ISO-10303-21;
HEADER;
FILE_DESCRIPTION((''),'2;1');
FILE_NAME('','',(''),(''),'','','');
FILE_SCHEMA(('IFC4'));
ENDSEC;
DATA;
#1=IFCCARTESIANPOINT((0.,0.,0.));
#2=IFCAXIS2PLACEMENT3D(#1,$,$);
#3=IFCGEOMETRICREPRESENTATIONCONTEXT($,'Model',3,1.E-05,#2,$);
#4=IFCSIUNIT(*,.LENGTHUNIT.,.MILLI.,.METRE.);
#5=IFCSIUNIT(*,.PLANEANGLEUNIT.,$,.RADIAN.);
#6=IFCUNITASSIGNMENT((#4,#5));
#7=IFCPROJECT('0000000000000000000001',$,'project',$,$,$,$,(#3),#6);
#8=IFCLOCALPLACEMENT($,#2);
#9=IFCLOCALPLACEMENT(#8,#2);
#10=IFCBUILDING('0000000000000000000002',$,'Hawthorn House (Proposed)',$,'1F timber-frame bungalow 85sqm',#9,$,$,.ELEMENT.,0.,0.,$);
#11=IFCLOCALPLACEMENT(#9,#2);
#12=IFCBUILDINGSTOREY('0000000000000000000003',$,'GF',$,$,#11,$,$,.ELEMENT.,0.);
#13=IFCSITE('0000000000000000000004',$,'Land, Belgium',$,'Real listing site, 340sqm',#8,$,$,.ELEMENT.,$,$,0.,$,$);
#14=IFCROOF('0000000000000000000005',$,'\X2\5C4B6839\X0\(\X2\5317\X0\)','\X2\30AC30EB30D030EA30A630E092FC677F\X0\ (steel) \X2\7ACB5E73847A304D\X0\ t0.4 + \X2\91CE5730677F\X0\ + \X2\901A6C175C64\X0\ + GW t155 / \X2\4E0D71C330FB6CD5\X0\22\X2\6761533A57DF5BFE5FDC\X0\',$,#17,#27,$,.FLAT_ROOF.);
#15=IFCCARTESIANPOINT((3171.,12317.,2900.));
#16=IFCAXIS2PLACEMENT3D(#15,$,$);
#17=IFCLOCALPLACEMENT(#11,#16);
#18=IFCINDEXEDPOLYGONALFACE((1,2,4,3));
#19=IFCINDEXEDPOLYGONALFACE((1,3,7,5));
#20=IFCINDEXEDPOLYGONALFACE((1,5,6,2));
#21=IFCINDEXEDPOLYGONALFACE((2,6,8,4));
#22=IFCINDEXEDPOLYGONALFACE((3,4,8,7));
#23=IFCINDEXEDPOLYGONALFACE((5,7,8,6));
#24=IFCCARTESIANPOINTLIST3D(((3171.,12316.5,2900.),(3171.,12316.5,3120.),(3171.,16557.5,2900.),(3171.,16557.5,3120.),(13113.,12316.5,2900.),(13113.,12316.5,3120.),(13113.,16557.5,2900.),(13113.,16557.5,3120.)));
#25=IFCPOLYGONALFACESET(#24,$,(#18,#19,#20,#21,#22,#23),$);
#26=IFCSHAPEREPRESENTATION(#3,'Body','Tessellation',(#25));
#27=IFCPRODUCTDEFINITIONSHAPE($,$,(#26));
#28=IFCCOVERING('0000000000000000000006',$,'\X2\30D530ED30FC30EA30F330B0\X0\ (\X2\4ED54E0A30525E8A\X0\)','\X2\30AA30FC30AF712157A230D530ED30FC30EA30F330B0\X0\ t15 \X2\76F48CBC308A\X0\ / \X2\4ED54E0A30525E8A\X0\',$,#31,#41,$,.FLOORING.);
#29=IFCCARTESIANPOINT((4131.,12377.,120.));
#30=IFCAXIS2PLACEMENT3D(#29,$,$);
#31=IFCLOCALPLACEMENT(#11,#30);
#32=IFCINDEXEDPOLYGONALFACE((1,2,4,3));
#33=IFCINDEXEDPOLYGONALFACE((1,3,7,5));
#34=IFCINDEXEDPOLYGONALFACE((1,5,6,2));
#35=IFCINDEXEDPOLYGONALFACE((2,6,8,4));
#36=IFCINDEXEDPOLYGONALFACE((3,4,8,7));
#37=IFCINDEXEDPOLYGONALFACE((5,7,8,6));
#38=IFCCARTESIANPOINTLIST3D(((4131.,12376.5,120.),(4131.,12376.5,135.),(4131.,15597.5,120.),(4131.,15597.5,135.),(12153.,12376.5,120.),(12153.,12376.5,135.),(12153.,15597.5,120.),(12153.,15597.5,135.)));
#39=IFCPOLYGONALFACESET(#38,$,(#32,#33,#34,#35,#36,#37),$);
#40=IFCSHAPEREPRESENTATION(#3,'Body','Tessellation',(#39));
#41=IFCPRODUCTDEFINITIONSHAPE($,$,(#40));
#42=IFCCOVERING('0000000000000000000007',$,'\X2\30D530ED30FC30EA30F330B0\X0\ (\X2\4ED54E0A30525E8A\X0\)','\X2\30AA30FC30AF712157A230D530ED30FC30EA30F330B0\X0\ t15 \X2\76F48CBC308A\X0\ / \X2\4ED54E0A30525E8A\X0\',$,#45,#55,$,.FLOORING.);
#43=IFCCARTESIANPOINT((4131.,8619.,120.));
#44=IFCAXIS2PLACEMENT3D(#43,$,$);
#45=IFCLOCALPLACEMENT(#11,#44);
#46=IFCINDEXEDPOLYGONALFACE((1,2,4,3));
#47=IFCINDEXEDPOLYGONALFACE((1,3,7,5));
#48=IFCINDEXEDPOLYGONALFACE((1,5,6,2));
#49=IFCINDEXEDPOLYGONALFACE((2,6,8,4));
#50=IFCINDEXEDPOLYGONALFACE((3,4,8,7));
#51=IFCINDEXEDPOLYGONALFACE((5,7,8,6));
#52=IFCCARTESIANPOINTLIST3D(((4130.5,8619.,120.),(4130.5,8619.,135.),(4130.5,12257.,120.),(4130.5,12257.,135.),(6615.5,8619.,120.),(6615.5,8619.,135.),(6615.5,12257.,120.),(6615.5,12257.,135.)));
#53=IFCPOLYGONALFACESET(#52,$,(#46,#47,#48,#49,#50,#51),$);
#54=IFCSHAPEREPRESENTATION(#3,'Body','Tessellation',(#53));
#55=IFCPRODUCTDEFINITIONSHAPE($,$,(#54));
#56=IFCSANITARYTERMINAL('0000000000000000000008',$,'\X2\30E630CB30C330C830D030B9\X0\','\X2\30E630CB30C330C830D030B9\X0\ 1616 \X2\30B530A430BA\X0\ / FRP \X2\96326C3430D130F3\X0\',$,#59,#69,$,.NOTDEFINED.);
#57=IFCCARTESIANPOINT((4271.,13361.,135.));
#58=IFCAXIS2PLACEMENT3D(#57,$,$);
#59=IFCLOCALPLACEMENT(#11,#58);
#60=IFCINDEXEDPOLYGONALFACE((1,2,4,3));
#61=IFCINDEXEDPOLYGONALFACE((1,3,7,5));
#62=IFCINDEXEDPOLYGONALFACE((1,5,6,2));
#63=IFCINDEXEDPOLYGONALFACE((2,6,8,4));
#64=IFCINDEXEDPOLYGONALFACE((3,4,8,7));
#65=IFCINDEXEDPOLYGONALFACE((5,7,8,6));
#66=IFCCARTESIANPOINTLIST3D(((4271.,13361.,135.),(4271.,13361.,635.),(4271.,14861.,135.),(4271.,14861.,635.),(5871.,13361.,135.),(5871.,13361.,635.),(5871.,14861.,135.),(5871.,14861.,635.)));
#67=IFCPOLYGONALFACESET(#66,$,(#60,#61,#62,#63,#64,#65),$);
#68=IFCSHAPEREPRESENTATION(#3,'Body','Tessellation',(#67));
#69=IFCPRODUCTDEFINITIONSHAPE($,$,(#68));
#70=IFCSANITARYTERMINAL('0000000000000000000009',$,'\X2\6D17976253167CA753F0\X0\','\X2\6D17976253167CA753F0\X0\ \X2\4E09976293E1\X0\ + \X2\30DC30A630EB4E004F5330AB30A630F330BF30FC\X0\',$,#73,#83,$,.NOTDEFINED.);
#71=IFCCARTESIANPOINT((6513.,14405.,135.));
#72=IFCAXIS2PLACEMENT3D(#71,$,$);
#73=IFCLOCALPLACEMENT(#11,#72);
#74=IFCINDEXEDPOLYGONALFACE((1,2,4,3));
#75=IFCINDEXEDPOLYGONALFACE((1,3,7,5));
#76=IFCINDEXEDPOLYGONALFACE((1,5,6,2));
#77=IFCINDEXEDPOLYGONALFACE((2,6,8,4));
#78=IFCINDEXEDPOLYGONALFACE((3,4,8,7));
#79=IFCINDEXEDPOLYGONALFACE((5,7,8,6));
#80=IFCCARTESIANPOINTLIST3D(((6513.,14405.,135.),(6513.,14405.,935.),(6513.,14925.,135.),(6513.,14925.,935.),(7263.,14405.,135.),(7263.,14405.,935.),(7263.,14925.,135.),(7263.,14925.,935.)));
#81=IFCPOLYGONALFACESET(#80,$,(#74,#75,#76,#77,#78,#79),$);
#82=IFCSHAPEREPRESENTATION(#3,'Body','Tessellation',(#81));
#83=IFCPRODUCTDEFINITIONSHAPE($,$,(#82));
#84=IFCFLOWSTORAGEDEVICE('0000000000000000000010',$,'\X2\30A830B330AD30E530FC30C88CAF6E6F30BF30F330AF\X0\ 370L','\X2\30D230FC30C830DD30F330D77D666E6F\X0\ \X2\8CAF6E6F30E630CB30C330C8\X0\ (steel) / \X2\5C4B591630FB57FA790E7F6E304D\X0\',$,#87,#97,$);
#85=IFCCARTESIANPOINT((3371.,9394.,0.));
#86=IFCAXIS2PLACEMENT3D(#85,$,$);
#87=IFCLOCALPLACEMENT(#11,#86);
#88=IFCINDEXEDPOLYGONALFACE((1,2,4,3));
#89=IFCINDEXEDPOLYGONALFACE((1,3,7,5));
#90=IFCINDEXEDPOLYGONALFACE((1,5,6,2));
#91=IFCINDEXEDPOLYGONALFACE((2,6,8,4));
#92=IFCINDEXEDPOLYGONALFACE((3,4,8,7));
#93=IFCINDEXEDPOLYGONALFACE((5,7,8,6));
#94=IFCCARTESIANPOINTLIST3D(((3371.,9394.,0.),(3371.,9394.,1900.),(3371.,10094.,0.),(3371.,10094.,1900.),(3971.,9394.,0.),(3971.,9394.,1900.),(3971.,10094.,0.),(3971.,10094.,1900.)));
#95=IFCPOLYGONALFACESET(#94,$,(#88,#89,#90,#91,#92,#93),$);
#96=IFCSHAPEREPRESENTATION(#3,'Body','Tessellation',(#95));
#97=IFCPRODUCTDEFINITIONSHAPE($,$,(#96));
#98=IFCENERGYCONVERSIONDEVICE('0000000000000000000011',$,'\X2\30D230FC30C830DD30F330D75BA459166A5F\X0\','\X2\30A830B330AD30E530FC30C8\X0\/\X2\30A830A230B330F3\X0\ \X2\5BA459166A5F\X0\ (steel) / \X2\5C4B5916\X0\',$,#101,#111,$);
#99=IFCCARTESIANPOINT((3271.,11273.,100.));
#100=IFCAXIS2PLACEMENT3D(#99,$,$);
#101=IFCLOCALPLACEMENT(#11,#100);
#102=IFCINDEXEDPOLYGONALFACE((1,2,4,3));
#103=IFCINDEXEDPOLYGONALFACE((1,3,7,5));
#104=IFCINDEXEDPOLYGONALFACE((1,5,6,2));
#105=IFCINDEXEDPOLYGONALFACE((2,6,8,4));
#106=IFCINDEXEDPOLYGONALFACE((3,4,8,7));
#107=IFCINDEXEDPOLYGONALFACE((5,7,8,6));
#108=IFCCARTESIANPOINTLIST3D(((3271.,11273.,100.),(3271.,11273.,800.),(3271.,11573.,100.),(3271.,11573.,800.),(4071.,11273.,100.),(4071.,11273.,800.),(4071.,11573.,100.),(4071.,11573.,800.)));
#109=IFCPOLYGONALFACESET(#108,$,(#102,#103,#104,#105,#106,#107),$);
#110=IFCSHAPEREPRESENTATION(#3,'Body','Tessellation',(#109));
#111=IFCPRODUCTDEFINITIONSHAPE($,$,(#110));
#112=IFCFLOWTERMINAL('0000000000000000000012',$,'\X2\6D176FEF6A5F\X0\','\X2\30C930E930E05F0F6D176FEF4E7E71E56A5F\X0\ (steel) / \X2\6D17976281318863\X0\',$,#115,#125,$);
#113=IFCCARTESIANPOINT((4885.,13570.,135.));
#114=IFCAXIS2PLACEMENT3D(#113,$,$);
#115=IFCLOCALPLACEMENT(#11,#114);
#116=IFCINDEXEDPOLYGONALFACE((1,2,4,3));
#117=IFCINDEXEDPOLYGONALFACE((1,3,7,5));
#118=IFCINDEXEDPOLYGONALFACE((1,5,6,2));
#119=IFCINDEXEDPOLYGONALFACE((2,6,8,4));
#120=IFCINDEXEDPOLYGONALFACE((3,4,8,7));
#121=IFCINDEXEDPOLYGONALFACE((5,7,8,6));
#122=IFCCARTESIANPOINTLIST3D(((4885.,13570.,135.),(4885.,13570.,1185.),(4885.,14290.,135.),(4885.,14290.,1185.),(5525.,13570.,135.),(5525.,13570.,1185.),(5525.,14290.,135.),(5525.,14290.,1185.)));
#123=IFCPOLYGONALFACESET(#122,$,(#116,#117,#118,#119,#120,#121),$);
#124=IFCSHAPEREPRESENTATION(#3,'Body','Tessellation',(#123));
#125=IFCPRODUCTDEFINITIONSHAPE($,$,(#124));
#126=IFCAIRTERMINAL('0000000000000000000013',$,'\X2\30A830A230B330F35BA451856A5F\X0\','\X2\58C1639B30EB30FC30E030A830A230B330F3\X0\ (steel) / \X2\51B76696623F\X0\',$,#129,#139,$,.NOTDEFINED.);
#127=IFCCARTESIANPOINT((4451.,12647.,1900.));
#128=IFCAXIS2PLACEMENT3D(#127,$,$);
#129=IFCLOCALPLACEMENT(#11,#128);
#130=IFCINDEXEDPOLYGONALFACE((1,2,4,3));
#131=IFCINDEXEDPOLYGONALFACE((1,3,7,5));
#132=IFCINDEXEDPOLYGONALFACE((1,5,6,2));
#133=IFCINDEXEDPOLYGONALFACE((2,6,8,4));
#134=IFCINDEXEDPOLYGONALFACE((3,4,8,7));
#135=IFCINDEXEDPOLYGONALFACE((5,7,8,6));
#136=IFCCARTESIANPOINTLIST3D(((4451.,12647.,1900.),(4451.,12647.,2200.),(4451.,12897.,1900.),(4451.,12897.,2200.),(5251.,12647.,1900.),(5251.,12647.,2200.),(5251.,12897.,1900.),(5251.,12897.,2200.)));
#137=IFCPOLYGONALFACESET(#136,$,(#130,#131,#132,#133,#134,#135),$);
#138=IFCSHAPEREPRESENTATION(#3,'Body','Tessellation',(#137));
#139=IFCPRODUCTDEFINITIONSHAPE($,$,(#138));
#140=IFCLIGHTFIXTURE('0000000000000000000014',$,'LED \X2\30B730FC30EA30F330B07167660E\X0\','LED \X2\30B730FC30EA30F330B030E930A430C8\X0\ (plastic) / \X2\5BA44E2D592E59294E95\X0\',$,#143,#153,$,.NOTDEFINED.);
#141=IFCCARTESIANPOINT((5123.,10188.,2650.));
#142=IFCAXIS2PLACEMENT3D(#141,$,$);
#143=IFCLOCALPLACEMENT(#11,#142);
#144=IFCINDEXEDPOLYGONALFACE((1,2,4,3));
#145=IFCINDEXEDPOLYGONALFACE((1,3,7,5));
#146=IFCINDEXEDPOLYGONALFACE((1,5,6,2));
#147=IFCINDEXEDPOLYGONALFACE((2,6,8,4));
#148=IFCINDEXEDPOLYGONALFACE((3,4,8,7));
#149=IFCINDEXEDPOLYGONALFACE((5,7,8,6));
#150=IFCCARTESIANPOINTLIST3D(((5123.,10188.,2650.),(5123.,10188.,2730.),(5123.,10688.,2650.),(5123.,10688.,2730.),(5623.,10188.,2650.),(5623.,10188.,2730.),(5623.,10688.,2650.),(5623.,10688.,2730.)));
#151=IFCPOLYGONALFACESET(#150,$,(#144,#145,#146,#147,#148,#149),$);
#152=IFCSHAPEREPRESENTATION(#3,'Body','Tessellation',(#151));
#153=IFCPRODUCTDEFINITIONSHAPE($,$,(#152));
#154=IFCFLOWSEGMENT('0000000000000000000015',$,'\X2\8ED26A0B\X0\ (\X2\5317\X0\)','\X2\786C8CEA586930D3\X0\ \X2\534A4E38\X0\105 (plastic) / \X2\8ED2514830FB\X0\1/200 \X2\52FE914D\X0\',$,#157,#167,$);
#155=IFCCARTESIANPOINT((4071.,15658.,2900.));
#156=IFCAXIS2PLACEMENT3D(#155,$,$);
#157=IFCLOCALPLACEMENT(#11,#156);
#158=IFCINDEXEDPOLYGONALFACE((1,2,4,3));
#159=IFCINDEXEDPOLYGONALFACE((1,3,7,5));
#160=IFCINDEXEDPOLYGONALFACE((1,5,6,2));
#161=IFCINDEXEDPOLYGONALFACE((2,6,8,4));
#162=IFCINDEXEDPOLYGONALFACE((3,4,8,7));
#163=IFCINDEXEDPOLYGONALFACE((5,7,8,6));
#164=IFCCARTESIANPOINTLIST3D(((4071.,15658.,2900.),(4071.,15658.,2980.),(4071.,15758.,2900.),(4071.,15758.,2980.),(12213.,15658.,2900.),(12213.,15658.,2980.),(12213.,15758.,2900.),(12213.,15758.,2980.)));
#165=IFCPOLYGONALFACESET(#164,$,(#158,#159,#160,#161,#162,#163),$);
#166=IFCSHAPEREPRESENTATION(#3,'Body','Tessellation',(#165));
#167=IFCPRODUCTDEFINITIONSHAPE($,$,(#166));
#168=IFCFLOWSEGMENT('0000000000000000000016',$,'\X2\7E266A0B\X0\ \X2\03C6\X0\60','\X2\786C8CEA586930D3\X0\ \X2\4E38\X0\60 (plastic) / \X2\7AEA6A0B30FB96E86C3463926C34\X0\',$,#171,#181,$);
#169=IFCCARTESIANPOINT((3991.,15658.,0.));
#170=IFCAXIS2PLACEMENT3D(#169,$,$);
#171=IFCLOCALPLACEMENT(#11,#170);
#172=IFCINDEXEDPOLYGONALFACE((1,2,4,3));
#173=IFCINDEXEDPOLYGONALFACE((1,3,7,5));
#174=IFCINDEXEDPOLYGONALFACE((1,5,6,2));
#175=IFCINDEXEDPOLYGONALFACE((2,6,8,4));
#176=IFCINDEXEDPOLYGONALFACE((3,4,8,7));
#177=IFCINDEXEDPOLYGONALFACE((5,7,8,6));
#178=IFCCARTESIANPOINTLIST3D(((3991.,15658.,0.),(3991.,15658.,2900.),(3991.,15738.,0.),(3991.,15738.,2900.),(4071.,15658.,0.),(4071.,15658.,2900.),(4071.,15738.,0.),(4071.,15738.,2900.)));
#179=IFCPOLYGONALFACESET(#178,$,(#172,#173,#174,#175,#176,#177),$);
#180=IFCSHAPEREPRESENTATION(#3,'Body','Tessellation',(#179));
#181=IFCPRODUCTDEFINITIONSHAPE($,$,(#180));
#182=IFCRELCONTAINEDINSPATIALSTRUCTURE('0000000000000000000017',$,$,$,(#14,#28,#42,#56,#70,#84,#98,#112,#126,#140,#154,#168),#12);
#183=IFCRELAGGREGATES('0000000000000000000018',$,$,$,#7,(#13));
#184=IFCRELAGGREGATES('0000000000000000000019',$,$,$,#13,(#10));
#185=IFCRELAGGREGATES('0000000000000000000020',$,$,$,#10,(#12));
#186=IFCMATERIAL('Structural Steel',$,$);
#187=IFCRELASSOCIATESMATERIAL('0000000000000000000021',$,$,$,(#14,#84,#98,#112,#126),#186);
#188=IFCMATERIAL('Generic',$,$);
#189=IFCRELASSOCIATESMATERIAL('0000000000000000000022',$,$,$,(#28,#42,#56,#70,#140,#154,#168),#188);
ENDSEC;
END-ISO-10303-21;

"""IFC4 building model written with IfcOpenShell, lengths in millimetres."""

from ifc_helpers import new_model, si_unit, frame, frame_2d, origin, place, context, project, spatial, rectangle, extrude, material, element, save


model = new_model("IFC4")

# Units and contexts
model_context = context("Model", 3, precision=1e-05, world=origin())
ifc_project = project(units=[si_unit("LENGTHUNIT", "METRE", prefix="MILLI"), si_unit("PLANEANGLEUNIT", "RADIAN")], contexts=[model_context])

# Site, building, storey
site_placement = place(None, origin())
site = spatial("IfcSite", under=ifc_project, at=site_placement, Name="Land, Belgium", ObjectType="Real listing site, 340sqm", CompositionType="ELEMENT", RefElevation=0.0)
building_placement = place(site_placement, origin())
building = spatial("IfcBuilding", under=site, at=building_placement, Name="Hawthorn House (Proposed)", ObjectType="1F timber-frame bungalow 85sqm", CompositionType="ELEMENT", ElevationOfRefHeight=0.0, ElevationOfTerrain=0.0)
storey_placement = place(building_placement, origin())
storey = spatial("IfcBuildingStorey", under=building, at=storey_placement, Name="GF", CompositionType="ELEMENT", Elevation=0.0)

# Roof
ifc_material_1 = material(Name="Structural Steel")
roof_placement = place(storey_placement, frame((3171.0, 12317.0, 2900.0)))
element("IfcRoof", 1, at=roof_placement, inside=storey, material=ifc_material_1, Name="屋根(北)", Description="ガルバリウム鋼板 (steel) 立平葺き t0.4 + 野地板 + 通気層 + GW t155 / 不燃・法22条区域対応", PredefinedType="FLAT_ROOF", context=model_context, shape_type="SweptSolid", body=[
    extrude(rectangle(XDim=9942.0, YDim=4241.0, at=frame_2d((4971.0, 2120.0))), frame((3171.0, 12317.0, 2900.0)), (0.0, 0.0, 1.0), 220.0),
])

# Coverings
ifc_material_2 = material(Name="Generic")
covering_1_placement = place(storey_placement, frame((4131.0, 12377.0, 120.0)))
element("IfcCovering", 2, at=covering_1_placement, inside=storey, material=ifc_material_2, Name="フローリング (仕上げ床)", Description="オーク無垢フローリング t15 直貼り / 仕上げ床", PredefinedType="FLOORING", context=model_context, shape_type="SweptSolid", body=[
    extrude(rectangle(XDim=8022.0, YDim=3221.0, at=frame_2d((4011.0, 1610.0))), frame((4131.0, 12377.0, 120.0)), (0.0, 0.0, 1.0), 15.0),
])
covering_2_placement = place(storey_placement, frame((4131.0, 8619.0, 120.0)))
element("IfcCovering", 3, at=covering_2_placement, inside=storey, material=ifc_material_2, Name="フローリング (仕上げ床)", Description="オーク無垢フローリング t15 直貼り / 仕上げ床", PredefinedType="FLOORING", context=model_context, shape_type="SweptSolid", body=[
    extrude(rectangle(XDim=2485.0, YDim=3638.0, at=frame_2d((1242.0, 1819.0))), frame((4131.0, 8619.0, 120.0)), (0.0, 0.0, 1.0), 15.0),
])

# Sanitary terminals
sanitary_terminal_1_placement = place(storey_placement, frame((4271.0, 13361.0, 135.0)))
element("IfcSanitaryTerminal", 4, at=sanitary_terminal_1_placement, inside=storey, material=ifc_material_2, Name="ユニットバス", Description="ユニットバス 1616 サイズ / FRP 防水パン", PredefinedType="NOTDEFINED", context=model_context, shape_type="SweptSolid", body=[
    extrude(rectangle(XDim=1600.0, YDim=1500.0, at=frame_2d((800.0, 750.0))), frame((4271.0, 13361.0, 135.0)), (0.0, 0.0, 1.0), 500.0),
])
sanitary_terminal_2_placement = place(storey_placement, frame((6513.0, 14405.0, 135.0)))
element("IfcSanitaryTerminal", 5, at=sanitary_terminal_2_placement, inside=storey, material=ifc_material_2, Name="洗面化粧台", Description="洗面化粧台 三面鏡 + ボウル一体カウンター", PredefinedType="NOTDEFINED", context=model_context, shape_type="SweptSolid", body=[
    extrude(rectangle(XDim=750.0, YDim=520.0, at=frame_2d((375.0, 260.0))), frame((6513.0, 14405.0, 135.0)), (0.0, 0.0, 1.0), 800.0),
])

# Flow storage device
flow_storage_device_placement = place(storey_placement, frame((3371.0, 9394.0, 0.0)))
element("IfcFlowStorageDevice", 6, at=flow_storage_device_placement, inside=storey, material=ifc_material_1, Name="エコキュート貯湯タンク 370L", Description="ヒートポンプ給湯 貯湯ユニット (steel) / 屋外・基礎置き", context=model_context, shape_type="SweptSolid", body=[
    extrude(rectangle(XDim=600.0, YDim=700.0, at=frame_2d((300.0, 350.0))), frame((3371.0, 9394.0, 0.0)), (0.0, 0.0, 1.0), 1900.0),
])

# Energy conversion device
energy_conversion_device_placement = place(storey_placement, frame((3271.0, 11273.0, 100.0)))
element("IfcEnergyConversionDevice", 7, at=energy_conversion_device_placement, inside=storey, material=ifc_material_1, Name="ヒートポンプ室外機", Description="エコキュート/エアコン 室外機 (steel) / 屋外", context=model_context, shape_type="SweptSolid", body=[
    extrude(rectangle(XDim=800.0, YDim=300.0, at=frame_2d((400.0, 150.0))), frame((3271.0, 11273.0, 100.0)), (0.0, 0.0, 1.0), 700.0),
])

# Flow terminal
flow_terminal_placement = place(storey_placement, frame((4885.0, 13570.0, 135.0)))
element("IfcFlowTerminal", 8, at=flow_terminal_placement, inside=storey, material=ifc_material_1, Name="洗濯機", Description="ドラム式洗濯乾燥機 (steel) / 洗面脱衣", context=model_context, shape_type="SweptSolid", body=[
    extrude(rectangle(XDim=640.0, YDim=720.0, at=frame_2d((320.0, 360.0))), frame((4885.0, 13570.0, 135.0)), (0.0, 0.0, 1.0), 1050.0),
])

# Air terminal
air_terminal_placement = place(storey_placement, frame((4451.0, 12647.0, 1900.0)))
element("IfcAirTerminal", 9, at=air_terminal_placement, inside=storey, material=ifc_material_1, Name="エアコン室内機", Description="壁掛ルームエアコン (steel) / 冷暖房", PredefinedType="NOTDEFINED", context=model_context, shape_type="SweptSolid", body=[
    extrude(rectangle(XDim=800.0, YDim=250.0, at=frame_2d((400.0, 125.0))), frame((4451.0, 12647.0, 1900.0)), (0.0, 0.0, 1.0), 300.0),
])

# Light fixture
light_fixture_placement = place(storey_placement, frame((5123.0, 10188.0, 2650.0)))
element("IfcLightFixture", 10, at=light_fixture_placement, inside=storey, material=ifc_material_2, Name="LED シーリング照明", Description="LED シーリングライト (plastic) / 室中央天井", PredefinedType="NOTDEFINED", context=model_context, shape_type="SweptSolid", body=[
    extrude(rectangle(XDim=500.0, YDim=500.0, at=frame_2d((250.0, 250.0))), frame((5123.0, 10188.0, 2650.0)), (0.0, 0.0, 1.0), 80.0),
])

# Flow segments
flow_segment_1_placement = place(storey_placement, frame((4071.0, 15658.0, 2900.0)))
element("IfcFlowSegment", 11, at=flow_segment_1_placement, inside=storey, material=ifc_material_2, Name="軒樋 (北)", Description="硬質塩ビ 半丸105 (plastic) / 軒先・1/200 勾配", context=model_context, shape_type="SweptSolid", body=[
    extrude(rectangle(XDim=8142.0, YDim=100.0, at=frame_2d((4071.0, 50.0))), frame((4071.0, 15658.0, 2900.0)), (0.0, 0.0, 1.0), 80.0),
])
flow_segment_2_placement = place(storey_placement, frame((3991.0, 15658.0, 0.0)))
element("IfcFlowSegment", 12, at=flow_segment_2_placement, inside=storey, material=ifc_material_2, Name="縦樋 φ60", Description="硬質塩ビ 丸60 (plastic) / 竪樋・雨水排水", context=model_context, shape_type="SweptSolid", body=[
    extrude(rectangle(XDim=80.0, YDim=80.0, at=frame_2d((40.0, 40.0))), frame((3991.0, 15658.0, 0.0)), (0.0, 0.0, 1.0), 2900.0),
])

save(model, "model.ifc")
